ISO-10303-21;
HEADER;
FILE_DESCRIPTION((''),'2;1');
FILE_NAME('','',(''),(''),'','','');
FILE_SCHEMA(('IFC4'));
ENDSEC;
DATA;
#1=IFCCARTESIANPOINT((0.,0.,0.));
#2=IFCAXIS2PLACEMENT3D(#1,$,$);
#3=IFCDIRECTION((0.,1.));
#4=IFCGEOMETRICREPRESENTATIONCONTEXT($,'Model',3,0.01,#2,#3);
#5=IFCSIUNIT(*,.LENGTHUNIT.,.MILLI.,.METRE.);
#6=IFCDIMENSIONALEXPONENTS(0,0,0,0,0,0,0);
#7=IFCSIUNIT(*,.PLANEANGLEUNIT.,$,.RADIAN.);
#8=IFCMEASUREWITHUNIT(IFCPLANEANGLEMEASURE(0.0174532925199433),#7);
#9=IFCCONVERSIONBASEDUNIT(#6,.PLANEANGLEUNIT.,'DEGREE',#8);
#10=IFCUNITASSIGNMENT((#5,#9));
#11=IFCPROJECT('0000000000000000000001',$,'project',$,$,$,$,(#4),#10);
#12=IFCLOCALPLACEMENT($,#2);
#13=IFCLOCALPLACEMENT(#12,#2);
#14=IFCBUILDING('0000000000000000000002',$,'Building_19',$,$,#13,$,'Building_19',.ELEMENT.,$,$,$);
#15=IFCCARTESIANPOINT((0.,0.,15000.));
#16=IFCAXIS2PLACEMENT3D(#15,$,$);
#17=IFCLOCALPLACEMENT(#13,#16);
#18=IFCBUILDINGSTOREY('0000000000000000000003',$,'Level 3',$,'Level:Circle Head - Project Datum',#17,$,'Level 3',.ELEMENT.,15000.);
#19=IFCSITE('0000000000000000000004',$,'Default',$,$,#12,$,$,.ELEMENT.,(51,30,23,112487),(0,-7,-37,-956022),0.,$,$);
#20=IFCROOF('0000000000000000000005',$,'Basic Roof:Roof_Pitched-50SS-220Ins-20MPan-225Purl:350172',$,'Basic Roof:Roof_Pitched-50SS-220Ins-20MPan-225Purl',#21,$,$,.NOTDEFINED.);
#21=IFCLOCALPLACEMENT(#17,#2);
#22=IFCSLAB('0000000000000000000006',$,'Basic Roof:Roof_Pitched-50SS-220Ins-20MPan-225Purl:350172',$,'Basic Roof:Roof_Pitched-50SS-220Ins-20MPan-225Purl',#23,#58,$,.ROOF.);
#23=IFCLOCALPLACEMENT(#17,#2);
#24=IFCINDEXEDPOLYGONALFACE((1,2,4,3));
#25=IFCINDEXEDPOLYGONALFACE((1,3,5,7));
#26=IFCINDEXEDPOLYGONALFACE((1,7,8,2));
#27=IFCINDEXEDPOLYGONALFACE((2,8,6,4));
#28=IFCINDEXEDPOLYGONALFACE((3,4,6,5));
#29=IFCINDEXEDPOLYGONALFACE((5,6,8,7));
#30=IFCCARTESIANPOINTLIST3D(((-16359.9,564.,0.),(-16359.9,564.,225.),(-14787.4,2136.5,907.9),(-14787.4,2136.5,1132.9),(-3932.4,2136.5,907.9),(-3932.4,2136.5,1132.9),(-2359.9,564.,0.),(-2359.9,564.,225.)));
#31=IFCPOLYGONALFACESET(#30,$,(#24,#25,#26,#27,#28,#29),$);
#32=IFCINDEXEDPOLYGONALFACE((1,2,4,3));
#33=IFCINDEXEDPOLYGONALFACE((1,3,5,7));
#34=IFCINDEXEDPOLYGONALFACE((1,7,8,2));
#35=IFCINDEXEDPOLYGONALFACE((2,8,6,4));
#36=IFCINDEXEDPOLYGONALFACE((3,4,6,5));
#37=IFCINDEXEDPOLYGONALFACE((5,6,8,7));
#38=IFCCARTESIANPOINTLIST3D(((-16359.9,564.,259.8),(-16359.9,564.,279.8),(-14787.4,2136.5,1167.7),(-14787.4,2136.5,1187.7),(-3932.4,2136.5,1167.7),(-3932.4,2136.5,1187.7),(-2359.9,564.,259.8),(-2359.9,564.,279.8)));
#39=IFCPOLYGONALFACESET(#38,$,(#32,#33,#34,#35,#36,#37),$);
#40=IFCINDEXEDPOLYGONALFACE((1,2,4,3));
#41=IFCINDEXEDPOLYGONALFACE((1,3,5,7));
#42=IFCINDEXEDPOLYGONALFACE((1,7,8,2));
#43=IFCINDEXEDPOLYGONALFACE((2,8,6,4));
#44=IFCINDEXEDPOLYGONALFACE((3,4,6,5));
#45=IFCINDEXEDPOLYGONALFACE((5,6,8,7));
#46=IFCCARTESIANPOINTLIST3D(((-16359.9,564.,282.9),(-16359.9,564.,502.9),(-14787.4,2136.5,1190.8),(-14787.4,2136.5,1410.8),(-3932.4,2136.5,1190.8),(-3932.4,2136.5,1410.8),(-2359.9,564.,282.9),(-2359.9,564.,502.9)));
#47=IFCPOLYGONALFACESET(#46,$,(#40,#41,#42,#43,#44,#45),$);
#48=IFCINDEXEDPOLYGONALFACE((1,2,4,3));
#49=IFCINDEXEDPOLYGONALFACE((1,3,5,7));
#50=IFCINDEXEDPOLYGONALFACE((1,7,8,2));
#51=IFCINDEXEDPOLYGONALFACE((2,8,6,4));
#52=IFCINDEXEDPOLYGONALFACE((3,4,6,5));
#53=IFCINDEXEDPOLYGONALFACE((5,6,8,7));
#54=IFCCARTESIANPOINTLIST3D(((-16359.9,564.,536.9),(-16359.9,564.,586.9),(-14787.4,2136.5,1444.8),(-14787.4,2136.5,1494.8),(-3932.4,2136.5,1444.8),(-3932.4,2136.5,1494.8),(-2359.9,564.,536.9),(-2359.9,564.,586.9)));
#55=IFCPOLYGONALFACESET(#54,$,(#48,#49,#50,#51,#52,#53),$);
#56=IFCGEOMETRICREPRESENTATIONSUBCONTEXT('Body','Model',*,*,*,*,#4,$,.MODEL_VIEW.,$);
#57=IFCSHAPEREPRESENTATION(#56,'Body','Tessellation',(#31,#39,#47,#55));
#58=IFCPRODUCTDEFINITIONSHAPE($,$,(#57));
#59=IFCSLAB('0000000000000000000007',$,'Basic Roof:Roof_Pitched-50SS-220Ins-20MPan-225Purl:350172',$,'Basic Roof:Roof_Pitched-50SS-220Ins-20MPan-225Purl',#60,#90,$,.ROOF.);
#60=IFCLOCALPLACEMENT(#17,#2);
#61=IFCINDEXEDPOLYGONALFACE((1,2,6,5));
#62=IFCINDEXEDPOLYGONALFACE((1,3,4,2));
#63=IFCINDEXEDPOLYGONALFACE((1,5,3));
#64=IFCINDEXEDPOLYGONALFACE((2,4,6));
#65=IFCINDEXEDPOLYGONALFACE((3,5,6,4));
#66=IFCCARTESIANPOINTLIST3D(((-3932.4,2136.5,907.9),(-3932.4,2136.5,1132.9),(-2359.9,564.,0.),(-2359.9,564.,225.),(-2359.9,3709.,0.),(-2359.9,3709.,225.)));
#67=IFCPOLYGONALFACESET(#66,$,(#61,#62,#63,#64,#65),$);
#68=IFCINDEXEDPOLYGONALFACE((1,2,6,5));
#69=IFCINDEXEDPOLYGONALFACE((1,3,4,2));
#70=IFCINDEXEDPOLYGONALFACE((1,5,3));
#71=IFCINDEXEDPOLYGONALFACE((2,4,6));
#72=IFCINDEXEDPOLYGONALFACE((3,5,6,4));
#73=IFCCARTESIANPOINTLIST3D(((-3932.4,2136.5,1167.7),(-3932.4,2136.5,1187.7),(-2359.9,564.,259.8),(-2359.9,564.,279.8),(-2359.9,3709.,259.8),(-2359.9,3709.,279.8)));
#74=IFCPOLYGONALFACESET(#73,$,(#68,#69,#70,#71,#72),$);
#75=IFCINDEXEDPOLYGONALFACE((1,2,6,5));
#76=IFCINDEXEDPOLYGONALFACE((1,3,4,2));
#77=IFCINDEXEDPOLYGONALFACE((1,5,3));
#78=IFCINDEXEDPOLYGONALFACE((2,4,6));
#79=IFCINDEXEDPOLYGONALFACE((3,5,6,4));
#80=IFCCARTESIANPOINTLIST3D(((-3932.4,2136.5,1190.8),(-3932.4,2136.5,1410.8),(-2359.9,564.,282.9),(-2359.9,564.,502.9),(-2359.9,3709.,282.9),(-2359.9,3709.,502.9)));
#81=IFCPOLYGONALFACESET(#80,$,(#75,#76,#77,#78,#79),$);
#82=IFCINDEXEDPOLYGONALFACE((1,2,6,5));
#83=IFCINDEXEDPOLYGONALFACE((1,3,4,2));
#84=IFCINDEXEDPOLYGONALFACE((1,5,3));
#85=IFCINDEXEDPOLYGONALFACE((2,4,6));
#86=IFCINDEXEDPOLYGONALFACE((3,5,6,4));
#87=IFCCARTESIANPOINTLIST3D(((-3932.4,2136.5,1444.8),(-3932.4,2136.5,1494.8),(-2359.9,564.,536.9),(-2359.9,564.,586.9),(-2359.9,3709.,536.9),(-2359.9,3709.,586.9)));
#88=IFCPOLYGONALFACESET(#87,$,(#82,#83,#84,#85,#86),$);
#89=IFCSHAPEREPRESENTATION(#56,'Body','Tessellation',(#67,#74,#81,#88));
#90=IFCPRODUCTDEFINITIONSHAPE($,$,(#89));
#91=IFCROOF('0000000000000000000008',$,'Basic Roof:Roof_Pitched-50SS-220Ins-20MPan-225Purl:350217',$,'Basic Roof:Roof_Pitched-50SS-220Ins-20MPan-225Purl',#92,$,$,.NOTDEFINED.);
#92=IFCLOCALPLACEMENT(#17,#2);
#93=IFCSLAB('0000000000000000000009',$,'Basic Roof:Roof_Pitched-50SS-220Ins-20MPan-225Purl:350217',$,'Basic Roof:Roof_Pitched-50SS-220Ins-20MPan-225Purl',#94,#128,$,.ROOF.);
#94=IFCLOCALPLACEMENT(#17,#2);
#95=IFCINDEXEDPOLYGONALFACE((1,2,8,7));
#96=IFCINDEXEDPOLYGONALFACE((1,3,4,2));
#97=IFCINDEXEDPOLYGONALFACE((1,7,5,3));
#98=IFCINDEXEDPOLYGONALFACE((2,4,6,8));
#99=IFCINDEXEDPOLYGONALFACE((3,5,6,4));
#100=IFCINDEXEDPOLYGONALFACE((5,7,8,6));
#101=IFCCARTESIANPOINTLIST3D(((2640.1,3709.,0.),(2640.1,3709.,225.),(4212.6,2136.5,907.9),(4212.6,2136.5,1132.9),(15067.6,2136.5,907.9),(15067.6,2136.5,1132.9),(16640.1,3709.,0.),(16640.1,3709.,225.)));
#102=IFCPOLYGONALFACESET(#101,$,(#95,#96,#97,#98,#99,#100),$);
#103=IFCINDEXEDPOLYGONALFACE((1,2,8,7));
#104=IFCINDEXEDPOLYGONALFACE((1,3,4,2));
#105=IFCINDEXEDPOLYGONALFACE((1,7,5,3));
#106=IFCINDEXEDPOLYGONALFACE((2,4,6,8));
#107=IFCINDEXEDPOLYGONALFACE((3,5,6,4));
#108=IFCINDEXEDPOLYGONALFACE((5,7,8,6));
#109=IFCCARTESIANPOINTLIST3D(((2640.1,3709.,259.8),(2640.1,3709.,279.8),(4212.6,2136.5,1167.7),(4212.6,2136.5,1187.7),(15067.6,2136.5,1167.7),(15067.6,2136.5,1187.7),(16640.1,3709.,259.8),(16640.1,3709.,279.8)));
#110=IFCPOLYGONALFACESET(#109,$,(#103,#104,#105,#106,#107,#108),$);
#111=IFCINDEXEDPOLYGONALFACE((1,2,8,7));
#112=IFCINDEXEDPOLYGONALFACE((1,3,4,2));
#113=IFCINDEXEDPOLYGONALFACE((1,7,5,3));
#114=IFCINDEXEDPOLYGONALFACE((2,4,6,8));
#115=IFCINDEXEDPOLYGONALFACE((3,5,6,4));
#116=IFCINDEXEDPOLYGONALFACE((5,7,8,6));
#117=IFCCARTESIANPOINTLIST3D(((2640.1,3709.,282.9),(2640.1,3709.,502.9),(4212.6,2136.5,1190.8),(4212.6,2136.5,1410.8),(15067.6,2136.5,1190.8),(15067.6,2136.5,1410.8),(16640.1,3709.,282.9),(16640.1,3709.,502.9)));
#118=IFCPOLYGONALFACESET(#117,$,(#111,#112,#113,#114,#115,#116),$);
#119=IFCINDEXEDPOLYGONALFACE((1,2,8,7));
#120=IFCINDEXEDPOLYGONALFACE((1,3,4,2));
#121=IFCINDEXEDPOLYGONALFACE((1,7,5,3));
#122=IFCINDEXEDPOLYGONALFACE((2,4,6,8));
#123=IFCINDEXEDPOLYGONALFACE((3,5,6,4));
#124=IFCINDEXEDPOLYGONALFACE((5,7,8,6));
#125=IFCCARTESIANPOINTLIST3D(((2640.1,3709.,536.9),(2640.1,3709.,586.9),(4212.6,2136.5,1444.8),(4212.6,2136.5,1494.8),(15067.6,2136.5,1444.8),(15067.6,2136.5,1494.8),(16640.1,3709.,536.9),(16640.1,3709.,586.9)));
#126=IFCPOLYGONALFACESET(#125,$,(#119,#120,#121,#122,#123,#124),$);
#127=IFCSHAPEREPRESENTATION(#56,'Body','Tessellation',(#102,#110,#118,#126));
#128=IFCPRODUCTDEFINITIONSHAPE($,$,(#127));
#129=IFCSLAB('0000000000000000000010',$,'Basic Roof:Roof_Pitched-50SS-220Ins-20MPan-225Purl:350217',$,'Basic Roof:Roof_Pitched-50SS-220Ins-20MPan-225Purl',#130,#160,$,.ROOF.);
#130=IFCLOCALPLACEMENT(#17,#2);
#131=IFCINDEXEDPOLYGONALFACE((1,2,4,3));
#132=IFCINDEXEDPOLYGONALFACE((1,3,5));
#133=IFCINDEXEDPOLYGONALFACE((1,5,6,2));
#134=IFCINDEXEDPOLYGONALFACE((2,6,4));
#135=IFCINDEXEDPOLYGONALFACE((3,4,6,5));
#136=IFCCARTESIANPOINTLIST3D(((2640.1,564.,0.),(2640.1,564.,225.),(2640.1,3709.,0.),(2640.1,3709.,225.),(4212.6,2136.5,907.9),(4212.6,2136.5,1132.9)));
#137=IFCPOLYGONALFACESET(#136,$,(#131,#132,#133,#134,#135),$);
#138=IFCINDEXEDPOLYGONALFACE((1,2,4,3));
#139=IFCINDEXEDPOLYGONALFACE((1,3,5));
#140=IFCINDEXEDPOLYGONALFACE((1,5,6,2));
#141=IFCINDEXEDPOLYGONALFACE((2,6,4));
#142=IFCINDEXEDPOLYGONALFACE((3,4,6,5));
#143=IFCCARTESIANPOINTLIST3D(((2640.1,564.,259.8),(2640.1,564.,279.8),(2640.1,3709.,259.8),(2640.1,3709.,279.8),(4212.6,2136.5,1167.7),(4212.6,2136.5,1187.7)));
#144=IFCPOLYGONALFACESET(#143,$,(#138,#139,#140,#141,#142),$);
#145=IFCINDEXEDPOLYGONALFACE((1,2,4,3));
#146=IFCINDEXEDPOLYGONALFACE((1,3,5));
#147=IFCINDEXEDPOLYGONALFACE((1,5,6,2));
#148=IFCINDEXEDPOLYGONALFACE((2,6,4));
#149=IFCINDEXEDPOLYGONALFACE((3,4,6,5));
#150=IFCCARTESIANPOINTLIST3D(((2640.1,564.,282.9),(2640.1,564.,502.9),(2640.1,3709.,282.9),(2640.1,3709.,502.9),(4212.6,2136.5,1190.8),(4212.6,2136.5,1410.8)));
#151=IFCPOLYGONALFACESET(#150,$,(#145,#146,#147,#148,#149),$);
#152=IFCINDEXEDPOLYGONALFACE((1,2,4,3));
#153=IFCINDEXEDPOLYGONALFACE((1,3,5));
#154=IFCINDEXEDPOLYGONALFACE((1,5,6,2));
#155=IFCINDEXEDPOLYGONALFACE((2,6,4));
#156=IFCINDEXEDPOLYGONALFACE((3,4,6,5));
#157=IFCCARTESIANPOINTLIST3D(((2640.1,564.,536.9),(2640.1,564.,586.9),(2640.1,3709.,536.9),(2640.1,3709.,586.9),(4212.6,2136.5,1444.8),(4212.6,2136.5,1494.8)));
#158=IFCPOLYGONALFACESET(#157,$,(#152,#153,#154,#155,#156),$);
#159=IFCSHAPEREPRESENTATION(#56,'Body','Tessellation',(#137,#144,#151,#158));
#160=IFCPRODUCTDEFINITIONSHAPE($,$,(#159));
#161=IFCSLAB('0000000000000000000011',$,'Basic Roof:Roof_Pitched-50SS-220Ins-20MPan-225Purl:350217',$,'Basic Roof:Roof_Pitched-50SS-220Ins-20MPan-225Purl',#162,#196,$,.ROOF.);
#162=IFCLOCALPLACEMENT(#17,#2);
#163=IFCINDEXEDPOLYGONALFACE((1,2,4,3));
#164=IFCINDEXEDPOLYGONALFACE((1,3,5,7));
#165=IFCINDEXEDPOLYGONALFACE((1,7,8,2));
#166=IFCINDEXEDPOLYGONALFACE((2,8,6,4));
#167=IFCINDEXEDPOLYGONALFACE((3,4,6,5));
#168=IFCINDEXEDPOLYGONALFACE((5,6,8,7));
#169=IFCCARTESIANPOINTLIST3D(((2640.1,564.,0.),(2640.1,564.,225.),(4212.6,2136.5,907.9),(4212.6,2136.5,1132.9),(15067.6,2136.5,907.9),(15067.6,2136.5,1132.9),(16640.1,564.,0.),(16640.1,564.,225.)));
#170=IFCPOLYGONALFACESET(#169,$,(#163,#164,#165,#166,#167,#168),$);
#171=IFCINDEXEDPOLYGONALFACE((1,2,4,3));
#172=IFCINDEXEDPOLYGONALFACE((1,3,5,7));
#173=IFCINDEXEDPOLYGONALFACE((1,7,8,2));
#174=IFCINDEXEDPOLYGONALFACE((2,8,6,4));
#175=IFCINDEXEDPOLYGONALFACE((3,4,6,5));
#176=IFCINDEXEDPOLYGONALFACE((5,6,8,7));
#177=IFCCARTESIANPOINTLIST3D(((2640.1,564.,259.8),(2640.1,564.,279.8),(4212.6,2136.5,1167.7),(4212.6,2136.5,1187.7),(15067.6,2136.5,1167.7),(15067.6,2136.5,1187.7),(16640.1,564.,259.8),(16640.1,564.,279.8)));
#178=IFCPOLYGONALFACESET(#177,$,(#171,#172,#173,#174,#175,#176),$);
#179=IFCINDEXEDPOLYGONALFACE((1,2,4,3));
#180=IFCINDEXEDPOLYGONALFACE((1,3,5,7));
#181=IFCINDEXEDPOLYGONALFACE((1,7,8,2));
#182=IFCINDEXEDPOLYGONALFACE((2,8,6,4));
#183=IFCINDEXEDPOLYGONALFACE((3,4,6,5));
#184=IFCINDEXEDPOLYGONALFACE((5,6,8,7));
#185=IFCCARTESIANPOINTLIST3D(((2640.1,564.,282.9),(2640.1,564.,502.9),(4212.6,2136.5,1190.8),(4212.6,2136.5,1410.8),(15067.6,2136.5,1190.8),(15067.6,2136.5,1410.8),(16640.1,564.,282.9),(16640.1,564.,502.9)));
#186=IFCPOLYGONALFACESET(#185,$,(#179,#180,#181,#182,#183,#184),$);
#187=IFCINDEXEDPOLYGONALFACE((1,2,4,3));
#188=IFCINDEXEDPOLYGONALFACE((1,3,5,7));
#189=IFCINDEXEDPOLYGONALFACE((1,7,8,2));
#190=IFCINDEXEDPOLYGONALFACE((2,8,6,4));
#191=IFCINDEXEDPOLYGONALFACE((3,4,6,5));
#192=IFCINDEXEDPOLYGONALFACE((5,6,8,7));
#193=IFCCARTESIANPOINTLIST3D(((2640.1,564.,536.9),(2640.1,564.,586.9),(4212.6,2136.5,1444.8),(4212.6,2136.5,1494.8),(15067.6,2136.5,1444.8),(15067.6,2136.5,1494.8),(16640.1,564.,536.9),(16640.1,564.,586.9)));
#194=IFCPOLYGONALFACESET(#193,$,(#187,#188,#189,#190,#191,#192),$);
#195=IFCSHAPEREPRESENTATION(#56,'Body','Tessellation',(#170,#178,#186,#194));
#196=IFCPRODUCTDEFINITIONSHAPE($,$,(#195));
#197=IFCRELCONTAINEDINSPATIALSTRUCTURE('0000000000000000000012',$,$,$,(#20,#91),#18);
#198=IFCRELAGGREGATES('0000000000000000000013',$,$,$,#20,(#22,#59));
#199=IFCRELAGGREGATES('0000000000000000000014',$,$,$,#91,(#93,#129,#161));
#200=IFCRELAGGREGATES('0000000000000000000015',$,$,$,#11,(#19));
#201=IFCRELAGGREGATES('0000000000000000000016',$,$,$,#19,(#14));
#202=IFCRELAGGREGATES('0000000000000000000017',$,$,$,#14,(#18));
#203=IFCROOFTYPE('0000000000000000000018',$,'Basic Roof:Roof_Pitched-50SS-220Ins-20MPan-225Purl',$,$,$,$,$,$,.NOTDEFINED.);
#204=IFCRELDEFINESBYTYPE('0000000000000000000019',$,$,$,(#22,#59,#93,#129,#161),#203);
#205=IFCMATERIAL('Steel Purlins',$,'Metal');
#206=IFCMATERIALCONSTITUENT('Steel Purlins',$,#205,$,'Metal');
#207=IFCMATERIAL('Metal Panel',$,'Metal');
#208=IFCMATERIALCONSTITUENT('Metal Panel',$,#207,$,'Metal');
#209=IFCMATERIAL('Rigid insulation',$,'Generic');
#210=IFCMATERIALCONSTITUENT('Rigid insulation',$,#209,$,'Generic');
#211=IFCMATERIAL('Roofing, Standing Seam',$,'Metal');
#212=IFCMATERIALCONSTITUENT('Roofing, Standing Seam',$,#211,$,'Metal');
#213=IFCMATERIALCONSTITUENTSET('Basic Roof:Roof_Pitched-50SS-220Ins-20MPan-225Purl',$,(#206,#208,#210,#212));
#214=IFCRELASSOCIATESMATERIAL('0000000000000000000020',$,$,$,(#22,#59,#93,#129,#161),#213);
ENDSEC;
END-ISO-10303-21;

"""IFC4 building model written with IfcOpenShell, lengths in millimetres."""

from ifc_helpers import new_model, entity, si_unit, converted_unit, direction, frame, origin, place, context, subcontext, project, spatial, indexed_curve, outline, extrude, material, constituent, constituent_set, type_object, element, aggregate, save


model = new_model("IFC4")

# Units and contexts
model_context = context("Model", 3, precision=0.01, world=origin(), true_north=direction((0.0, 1.0)))
body_context = subcontext(model_context, "Body", "Model", "MODEL_VIEW")
ifc_project = project(units=[si_unit("LENGTHUNIT", "METRE", prefix="MILLI"), converted_unit("PLANEANGLEUNIT", "DEGREE", entity("IfcPlaneAngleMeasure", 0.0174532925199433), si_unit("PLANEANGLEUNIT", "RADIAN"), dimensions=[0, 0, 0, 0, 0, 0, 0])], contexts=[model_context])

# Site, building, storey
site_placement = place(None, origin())
site = spatial("IfcSite", under=ifc_project, at=site_placement, Name="Default", CompositionType="ELEMENT", RefLatitude=(51, 30, 23, 112487), RefLongitude=(0, -7, -37, -956022), RefElevation=0.0)
building_placement = place(site_placement, origin())
building = spatial("IfcBuilding", under=site, at=building_placement, Name="Building_19", LongName="Building_19", CompositionType="ELEMENT")
storey_placement = place(building_placement, frame((0.0, 0.0, 15000.0)))
storey = spatial("IfcBuildingStorey", under=building, at=storey_placement, Name="Level 3", ObjectType="Level:Circle Head - Project Datum", LongName="Level 3", CompositionType="ELEMENT", Elevation=15000.0)

# Shared definitions
ifc_material_1 = material(Name="Rigid insulation", Category="Generic")

# Roofs, slabs
roof_1_placement = place(storey_placement, frame((-16359.9, 564.0, 0.0)))
roof_1 = element("IfcRoof", 1, at=roof_1_placement, inside=storey, Name="Basic Roof:Roof_Pitched-50SS-220Ins-20MPan-225Purl:350172", ObjectType="Basic Roof:Roof_Pitched-50SS-220Ins-20MPan-225Purl", PredefinedType="NOTDEFINED")
ifc_material_2 = material(Name="Steel Purlins", Category="Metal")
ifc_constituent_1 = constituent(ifc_material_2, Name="Steel Purlins", Category="Metal")
ifc_material_3 = material(Name="Metal Panel", Category="Metal")
ifc_constituent_2 = constituent(ifc_material_3, Name="Metal Panel", Category="Metal")
ifc_constituent_3 = constituent(ifc_material_1, Name="Rigid insulation", Category="Generic")
ifc_material_4 = material(Name="Roofing, Standing Seam", Category="Metal")
ifc_constituent_4 = constituent(ifc_material_4, Name="Roofing, Standing Seam", Category="Metal")
ifc_constituent_set_1 = constituent_set(constituents=[ifc_constituent_1, ifc_constituent_2, ifc_constituent_3, ifc_constituent_4], Name="Basic Roof:Roof_Pitched-50SS-220Ins-20MPan-225Purl")
roof_type = type_object("IfcRoofType", Name="Basic Roof:Roof_Pitched-50SS-220Ins-20MPan-225Purl", PredefinedType="NOTDEFINED")
slab_1_placement = place(roof_1_placement, origin())
slab_1 = element("IfcSlab", 2, at=slab_1_placement, type_object=roof_type, material=ifc_constituent_set_1, Name="Basic Roof:Roof_Pitched-50SS-220Ins-20MPan-225Purl:350172", ObjectType="Basic Roof:Roof_Pitched-50SS-220Ins-20MPan-225Purl", PredefinedType="ROOF", context=body_context, shape_type="SweptSolid", body=[
    extrude(outline(indexed_curve([(-7000.0, -907.9), (7000.0, -907.9), (5427.5, 907.9), (-5427.5, 907.9), (-7000.0, -907.9)], self_intersect=False)), frame((7000.0, 786.3, 453.9), z_axis=(0.0, -0.5, 0.866025), x_axis=(1.0, 0.0, 0.0)), (0.0, 0.5, 0.866025), 225.0),
    extrude(outline(indexed_curve([(-7000.0, -907.9), (7000.0, -907.9), (5427.5, 907.9), (-5427.5, 907.9), (-7000.0, -907.9)], self_intersect=False)), frame((7000.0, 786.3, 713.7), z_axis=(0.0, -0.5, 0.866025), x_axis=(1.0, 0.0, 0.0)), (0.0, 0.5, 0.866025), 20.0),
    extrude(outline(indexed_curve([(-7000.0, -907.9), (7000.0, -907.9), (5427.5, 907.9), (-5427.5, 907.9), (-7000.0, -907.9)], self_intersect=False)), frame((7000.0, 786.3, 736.8), z_axis=(0.0, -0.5, 0.866025), x_axis=(1.0, 0.0, 0.0)), (0.0, 0.5, 0.866025), 220.0),
    extrude(outline(indexed_curve([(-7000.0, -907.9), (7000.0, -907.9), (5427.5, 907.9), (-5427.5, 907.9), (-7000.0, -907.9)], self_intersect=False)), frame((7000.0, 786.3, 990.9), z_axis=(0.0, -0.5, 0.866025), x_axis=(1.0, 0.0, 0.0)), (0.0, 0.5, 0.866025), 50.0),
])
slab_2_placement = place(roof_1_placement, origin())
slab_2 = element("IfcSlab", 3, at=slab_2_placement, type_object=roof_type, material=ifc_constituent_set_1, Name="Basic Roof:Roof_Pitched-50SS-220Ins-20MPan-225Purl:350172", ObjectType="Basic Roof:Roof_Pitched-50SS-220Ins-20MPan-225Purl", PredefinedType="ROOF", context=body_context, shape_type="SweptSolid", body=[
    extrude(outline(indexed_curve([(-907.9, 0.0), (907.9, -1572.5), (907.9, 1572.5), (-907.9, 0.0)], self_intersect=False)), frame((13213.8, 1572.5, 453.9), z_axis=(0.5, 0.0, 0.866025), x_axis=(0.866025, 0.0, -0.5)), (-0.5, 0.0, 0.866025), 225.0),
    extrude(outline(indexed_curve([(-907.9, 0.0), (907.9, -1572.5), (907.9, 1572.5), (-907.9, 0.0)], self_intersect=False)), frame((13213.8, 1572.5, 713.7), z_axis=(0.5, 0.0, 0.866025), x_axis=(0.866025, 0.0, -0.5)), (-0.5, 0.0, 0.866025), 20.0),
    extrude(outline(indexed_curve([(-907.9, 0.0), (907.9, -1572.5), (907.9, 1572.5), (-907.9, 0.0)], self_intersect=False)), frame((13213.8, 1572.5, 736.8), z_axis=(0.5, 0.0, 0.866025), x_axis=(0.866025, 0.0, -0.5)), (-0.5, 0.0, 0.866025), 220.0),
    extrude(outline(indexed_curve([(-907.9, 0.0), (907.9, -1572.5), (907.9, 1572.5), (-907.9, 0.0)], self_intersect=False)), frame((13213.8, 1572.5, 990.9), z_axis=(0.5, 0.0, 0.866025), x_axis=(0.866025, 0.0, -0.5)), (-0.5, 0.0, 0.866025), 50.0),
])
aggregate(roof_1, [slab_1, slab_2])
roof_2_placement = place(storey_placement, frame((2640.1, 564.0, 0.0)))
roof_2 = element("IfcRoof", 4, at=roof_2_placement, inside=storey, Name="Basic Roof:Roof_Pitched-50SS-220Ins-20MPan-225Purl:350217", ObjectType="Basic Roof:Roof_Pitched-50SS-220Ins-20MPan-225Purl", PredefinedType="NOTDEFINED")
slab_3_placement = place(roof_2_placement, origin())
slab_3 = element("IfcSlab", 5, at=slab_3_placement, type_object=roof_type, material=ifc_constituent_set_1, Name="Basic Roof:Roof_Pitched-50SS-220Ins-20MPan-225Purl:350217", ObjectType="Basic Roof:Roof_Pitched-50SS-220Ins-20MPan-225Purl", PredefinedType="ROOF", context=body_context, shape_type="SweptSolid", body=[
    extrude(outline(indexed_curve([(7000.0, 907.9), (-7000.0, 907.9), (-5427.5, -907.9), (5427.5, -907.9), (7000.0, 907.9)], self_intersect=False)), frame((7000.0, 2358.8, 453.9), z_axis=(0.0, 0.5, 0.866025), x_axis=(1.0, 0.0, 0.0)), (0.0, -0.5, 0.866025), 225.0),
    extrude(outline(indexed_curve([(7000.0, 907.9), (-7000.0, 907.9), (-5427.5, -907.9), (5427.5, -907.9), (7000.0, 907.9)], self_intersect=False)), frame((7000.0, 2358.8, 713.7), z_axis=(0.0, 0.5, 0.866025), x_axis=(1.0, 0.0, 0.0)), (0.0, -0.5, 0.866025), 20.0),
    extrude(outline(indexed_curve([(7000.0, 907.9), (-7000.0, 907.9), (-5427.5, -907.9), (5427.5, -907.9), (7000.0, 907.9)], self_intersect=False)), frame((7000.0, 2358.8, 736.8), z_axis=(0.0, 0.5, 0.866025), x_axis=(1.0, 0.0, 0.0)), (0.0, -0.5, 0.866025), 220.0),
    extrude(outline(indexed_curve([(7000.0, 907.9), (-7000.0, 907.9), (-5427.5, -907.9), (5427.5, -907.9), (7000.0, 907.9)], self_intersect=False)), frame((7000.0, 2358.8, 990.9), z_axis=(0.0, 0.5, 0.866025), x_axis=(1.0, 0.0, 0.0)), (0.0, -0.5, 0.866025), 50.0),
])
slab_4_placement = place(roof_2_placement, origin())
slab_4 = element("IfcSlab", 6, at=slab_4_placement, type_object=roof_type, material=ifc_constituent_set_1, Name="Basic Roof:Roof_Pitched-50SS-220Ins-20MPan-225Purl:350217", ObjectType="Basic Roof:Roof_Pitched-50SS-220Ins-20MPan-225Purl", PredefinedType="ROOF", context=body_context, shape_type="SweptSolid", body=[
    extrude(outline(indexed_curve([(-907.9, 1572.5), (-907.9, -1572.5), (907.9, 0.0), (-907.9, 1572.5)], self_intersect=False)), frame((786.3, 1572.5, 453.9), z_axis=(-0.5, 0.0, 0.866025), x_axis=(0.866025, 0.0, 0.5)), (0.5, 0.0, 0.866025), 225.0),
    extrude(outline(indexed_curve([(-907.9, 1572.5), (-907.9, -1572.5), (907.9, 0.0), (-907.9, 1572.5)], self_intersect=False)), frame((786.3, 1572.5, 713.7), z_axis=(-0.5, 0.0, 0.866025), x_axis=(0.866025, 0.0, 0.5)), (0.5, 0.0, 0.866025), 20.0),
    extrude(outline(indexed_curve([(-907.9, 1572.5), (-907.9, -1572.5), (907.9, 0.0), (-907.9, 1572.5)], self_intersect=False)), frame((786.3, 1572.5, 736.8), z_axis=(-0.5, 0.0, 0.866025), x_axis=(0.866025, 0.0, 0.5)), (0.5, 0.0, 0.866025), 220.0),
    extrude(outline(indexed_curve([(-907.9, 1572.5), (-907.9, -1572.5), (907.9, 0.0), (-907.9, 1572.5)], self_intersect=False)), frame((786.3, 1572.5, 990.9), z_axis=(-0.5, 0.0, 0.866025), x_axis=(0.866025, 0.0, 0.5)), (0.5, 0.0, 0.866025), 50.0),
])
slab_5_placement = place(roof_2_placement, origin())
slab_5 = element("IfcSlab", 7, at=slab_5_placement, type_object=roof_type, material=ifc_constituent_set_1, Name="Basic Roof:Roof_Pitched-50SS-220Ins-20MPan-225Purl:350217", ObjectType="Basic Roof:Roof_Pitched-50SS-220Ins-20MPan-225Purl", PredefinedType="ROOF", context=body_context, shape_type="SweptSolid", body=[
    extrude(outline(indexed_curve([(-7000.0, -907.9), (7000.0, -907.9), (5427.5, 907.9), (-5427.5, 907.9), (-7000.0, -907.9)], self_intersect=False)), frame((7000.0, 786.3, 453.9), z_axis=(0.0, -0.5, 0.866025), x_axis=(1.0, 0.0, 0.0)), (0.0, 0.5, 0.866025), 225.0),
    extrude(outline(indexed_curve([(-7000.0, -907.9), (7000.0, -907.9), (5427.5, 907.9), (-5427.5, 907.9), (-7000.0, -907.9)], self_intersect=False)), frame((7000.0, 786.3, 713.7), z_axis=(0.0, -0.5, 0.866025), x_axis=(1.0, 0.0, 0.0)), (0.0, 0.5, 0.866025), 20.0),
    extrude(outline(indexed_curve([(-7000.0, -907.9), (7000.0, -907.9), (5427.5, 907.9), (-5427.5, 907.9), (-7000.0, -907.9)], self_intersect=False)), frame((7000.0, 786.3, 736.8), z_axis=(0.0, -0.5, 0.866025), x_axis=(1.0, 0.0, 0.0)), (0.0, 0.5, 0.866025), 220.0),
    extrude(outline(indexed_curve([(-7000.0, -907.9), (7000.0, -907.9), (5427.5, 907.9), (-5427.5, 907.9), (-7000.0, -907.9)], self_intersect=False)), frame((7000.0, 786.3, 990.9), z_axis=(0.0, -0.5, 0.866025), x_axis=(1.0, 0.0, 0.0)), (0.0, 0.5, 0.866025), 50.0),
])
aggregate(roof_2, [slab_3, slab_4, slab_5])

save(model, "model.ifc")
